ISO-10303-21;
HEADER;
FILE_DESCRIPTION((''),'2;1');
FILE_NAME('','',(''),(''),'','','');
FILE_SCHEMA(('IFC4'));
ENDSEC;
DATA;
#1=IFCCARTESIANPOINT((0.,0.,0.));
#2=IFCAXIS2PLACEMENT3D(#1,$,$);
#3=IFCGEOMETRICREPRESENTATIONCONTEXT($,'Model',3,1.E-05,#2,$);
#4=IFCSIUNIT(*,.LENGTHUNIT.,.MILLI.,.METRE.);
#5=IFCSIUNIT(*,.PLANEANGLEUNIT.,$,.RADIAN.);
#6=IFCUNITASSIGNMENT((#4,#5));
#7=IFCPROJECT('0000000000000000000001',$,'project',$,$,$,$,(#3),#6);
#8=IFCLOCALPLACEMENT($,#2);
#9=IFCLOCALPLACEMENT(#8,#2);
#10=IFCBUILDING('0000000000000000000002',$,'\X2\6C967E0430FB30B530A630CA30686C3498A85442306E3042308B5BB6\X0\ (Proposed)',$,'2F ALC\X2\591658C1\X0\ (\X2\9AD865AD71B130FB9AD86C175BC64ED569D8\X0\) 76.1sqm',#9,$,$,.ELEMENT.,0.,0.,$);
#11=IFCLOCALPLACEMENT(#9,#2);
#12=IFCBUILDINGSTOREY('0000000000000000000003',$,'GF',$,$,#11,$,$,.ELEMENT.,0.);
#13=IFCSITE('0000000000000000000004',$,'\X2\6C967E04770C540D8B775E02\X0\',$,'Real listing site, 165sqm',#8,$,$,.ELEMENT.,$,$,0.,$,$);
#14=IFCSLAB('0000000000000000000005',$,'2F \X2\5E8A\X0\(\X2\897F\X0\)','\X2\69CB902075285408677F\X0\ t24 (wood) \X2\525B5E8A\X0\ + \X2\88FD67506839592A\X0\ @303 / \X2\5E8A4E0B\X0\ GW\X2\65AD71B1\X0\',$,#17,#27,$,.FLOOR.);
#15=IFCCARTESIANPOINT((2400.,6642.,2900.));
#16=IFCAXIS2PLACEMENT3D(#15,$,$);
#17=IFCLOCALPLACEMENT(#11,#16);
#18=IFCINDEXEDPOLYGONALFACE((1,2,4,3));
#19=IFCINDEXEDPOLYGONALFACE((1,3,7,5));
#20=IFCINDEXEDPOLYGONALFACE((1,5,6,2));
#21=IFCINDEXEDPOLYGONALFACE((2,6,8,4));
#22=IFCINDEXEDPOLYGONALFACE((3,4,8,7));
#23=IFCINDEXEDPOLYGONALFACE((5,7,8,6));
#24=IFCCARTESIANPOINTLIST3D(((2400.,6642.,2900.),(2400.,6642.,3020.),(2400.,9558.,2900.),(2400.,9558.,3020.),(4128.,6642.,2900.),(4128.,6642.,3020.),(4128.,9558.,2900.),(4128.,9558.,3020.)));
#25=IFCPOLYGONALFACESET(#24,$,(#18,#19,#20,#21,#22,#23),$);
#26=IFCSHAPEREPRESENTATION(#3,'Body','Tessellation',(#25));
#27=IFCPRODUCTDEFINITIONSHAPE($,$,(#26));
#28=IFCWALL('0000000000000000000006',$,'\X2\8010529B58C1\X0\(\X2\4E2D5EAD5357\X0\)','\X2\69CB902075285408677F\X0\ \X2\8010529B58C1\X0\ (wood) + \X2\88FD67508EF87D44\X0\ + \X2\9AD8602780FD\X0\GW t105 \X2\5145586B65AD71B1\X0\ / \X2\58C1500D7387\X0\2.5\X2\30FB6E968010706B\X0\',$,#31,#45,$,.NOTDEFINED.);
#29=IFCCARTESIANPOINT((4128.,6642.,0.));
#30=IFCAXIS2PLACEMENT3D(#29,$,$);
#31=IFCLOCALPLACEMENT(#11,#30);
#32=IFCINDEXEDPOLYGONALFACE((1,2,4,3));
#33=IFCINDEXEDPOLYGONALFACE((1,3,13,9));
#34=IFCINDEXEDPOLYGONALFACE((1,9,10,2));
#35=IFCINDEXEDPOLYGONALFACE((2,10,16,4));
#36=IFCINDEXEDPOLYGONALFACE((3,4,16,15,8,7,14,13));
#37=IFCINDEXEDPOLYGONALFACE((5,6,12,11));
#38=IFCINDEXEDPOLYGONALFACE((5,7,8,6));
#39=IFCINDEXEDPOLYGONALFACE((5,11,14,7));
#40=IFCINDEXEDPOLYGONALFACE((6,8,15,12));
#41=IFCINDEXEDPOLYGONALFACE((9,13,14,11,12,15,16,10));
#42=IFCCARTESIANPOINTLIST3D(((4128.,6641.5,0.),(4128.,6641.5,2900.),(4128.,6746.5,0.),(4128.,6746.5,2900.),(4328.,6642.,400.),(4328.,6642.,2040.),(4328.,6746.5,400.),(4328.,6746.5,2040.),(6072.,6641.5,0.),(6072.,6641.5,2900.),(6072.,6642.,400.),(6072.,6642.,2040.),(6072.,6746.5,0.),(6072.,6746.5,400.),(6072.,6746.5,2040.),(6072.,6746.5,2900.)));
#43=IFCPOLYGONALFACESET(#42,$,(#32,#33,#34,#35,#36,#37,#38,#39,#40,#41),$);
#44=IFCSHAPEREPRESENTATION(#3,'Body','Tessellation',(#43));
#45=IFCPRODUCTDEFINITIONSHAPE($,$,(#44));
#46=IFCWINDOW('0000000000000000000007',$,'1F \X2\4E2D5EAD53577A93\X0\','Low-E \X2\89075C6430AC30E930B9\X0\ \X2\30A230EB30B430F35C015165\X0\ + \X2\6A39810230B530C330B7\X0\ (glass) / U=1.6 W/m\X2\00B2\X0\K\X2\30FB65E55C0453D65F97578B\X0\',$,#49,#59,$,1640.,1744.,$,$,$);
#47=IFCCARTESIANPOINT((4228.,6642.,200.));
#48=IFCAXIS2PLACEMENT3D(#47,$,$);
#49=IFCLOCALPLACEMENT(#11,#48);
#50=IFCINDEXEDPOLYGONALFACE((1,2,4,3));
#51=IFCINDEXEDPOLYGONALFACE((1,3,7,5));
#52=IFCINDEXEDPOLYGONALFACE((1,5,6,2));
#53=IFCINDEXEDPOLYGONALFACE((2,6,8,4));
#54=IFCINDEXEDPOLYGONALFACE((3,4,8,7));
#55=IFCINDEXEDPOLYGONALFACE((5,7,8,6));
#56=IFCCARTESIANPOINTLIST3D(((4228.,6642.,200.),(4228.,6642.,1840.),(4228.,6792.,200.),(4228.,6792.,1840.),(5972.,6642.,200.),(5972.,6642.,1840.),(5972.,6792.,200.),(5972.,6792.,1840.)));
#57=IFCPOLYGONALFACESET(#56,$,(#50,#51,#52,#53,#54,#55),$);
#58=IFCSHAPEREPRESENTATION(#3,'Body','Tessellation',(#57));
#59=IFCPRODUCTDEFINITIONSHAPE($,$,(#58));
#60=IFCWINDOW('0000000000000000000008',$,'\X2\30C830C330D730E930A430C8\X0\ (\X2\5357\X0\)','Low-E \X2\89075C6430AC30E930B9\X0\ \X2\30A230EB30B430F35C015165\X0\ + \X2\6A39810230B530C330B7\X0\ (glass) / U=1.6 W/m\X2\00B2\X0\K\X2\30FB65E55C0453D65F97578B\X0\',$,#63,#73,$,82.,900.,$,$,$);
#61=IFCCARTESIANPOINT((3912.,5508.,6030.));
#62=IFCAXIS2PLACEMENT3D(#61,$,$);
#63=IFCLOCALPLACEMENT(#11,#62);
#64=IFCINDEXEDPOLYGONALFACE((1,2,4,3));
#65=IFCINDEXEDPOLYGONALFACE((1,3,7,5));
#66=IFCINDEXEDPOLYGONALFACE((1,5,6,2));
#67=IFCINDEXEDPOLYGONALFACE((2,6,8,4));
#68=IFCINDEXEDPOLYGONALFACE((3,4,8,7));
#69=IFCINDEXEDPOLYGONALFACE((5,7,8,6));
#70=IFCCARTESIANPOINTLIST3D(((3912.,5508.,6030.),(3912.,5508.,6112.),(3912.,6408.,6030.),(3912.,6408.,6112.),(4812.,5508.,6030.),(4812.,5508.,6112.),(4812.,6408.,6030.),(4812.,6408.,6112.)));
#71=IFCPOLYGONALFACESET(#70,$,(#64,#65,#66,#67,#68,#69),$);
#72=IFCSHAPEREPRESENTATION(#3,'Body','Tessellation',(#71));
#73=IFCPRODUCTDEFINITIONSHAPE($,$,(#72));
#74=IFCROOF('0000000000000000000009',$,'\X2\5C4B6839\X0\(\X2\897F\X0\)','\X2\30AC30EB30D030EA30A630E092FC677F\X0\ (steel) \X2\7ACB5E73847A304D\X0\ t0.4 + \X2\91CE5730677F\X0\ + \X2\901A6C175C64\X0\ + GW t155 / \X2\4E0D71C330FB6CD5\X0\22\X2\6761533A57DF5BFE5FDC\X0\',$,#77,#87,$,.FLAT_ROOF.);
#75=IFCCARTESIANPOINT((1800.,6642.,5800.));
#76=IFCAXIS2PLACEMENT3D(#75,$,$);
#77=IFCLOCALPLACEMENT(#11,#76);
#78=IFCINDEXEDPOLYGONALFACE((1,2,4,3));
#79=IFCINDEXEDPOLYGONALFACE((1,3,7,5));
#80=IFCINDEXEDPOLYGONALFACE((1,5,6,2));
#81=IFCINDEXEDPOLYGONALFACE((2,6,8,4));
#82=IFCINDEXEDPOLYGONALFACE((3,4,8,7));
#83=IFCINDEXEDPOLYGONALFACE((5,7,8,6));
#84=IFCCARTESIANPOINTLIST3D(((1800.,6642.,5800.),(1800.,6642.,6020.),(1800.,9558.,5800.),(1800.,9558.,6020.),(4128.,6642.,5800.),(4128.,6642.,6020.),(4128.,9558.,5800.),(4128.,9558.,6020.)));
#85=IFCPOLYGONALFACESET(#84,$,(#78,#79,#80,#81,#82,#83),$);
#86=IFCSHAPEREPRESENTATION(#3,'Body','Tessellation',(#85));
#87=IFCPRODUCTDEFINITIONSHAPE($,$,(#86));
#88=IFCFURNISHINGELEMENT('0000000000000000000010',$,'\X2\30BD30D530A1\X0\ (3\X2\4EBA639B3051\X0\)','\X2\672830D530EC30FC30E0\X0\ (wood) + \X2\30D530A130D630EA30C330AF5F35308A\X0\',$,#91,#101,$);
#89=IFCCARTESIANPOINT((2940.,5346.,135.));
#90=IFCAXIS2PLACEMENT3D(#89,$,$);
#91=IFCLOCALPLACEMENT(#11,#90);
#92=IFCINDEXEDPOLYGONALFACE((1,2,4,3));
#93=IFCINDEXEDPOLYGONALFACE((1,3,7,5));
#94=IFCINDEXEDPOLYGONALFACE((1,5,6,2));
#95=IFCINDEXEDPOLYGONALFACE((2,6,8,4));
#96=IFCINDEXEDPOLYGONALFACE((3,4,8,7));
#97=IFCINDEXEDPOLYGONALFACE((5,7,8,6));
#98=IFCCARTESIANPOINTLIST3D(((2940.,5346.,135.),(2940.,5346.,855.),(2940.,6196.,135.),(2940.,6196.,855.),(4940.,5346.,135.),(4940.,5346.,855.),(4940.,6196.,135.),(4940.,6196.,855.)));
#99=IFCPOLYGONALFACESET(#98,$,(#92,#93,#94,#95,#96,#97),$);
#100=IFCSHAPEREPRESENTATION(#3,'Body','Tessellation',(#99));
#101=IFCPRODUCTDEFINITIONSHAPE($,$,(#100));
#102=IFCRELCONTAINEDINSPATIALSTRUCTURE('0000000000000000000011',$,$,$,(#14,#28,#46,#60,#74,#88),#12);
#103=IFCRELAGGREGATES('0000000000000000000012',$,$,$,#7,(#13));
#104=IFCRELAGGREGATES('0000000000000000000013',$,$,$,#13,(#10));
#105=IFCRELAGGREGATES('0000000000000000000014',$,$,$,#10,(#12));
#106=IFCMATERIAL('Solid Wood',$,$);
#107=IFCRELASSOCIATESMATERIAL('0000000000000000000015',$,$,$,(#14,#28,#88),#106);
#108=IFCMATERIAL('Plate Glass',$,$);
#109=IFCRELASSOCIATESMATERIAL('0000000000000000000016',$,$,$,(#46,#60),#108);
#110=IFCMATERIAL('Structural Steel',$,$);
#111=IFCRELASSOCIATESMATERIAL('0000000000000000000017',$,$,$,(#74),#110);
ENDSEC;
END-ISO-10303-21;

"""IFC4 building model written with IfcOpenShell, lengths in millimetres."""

from ifc_helpers import new_model, si_unit, frame, frame_2d, origin, place, context, project, spatial, rectangle, extrude, material, element, fill, save


model = new_model("IFC4")

# Units and contexts
model_context = context("Model", 3, precision=1e-05, world=origin())
ifc_project = project(units=[si_unit("LENGTHUNIT", "METRE", prefix="MILLI"), si_unit("PLANEANGLEUNIT", "RADIAN")], contexts=[model_context])

# Site, building, storey
site_placement = place(None, origin())
site = spatial("IfcSite", under=ifc_project, at=site_placement, Name="沖縄県名護市", ObjectType="Real listing site, 165sqm", CompositionType="ELEMENT", RefElevation=0.0)
building_placement = place(site_placement, origin())
building = spatial("IfcBuilding", under=site, at=building_placement, Name="沖縄・サウナと水風呂のある家 (Proposed)", ObjectType="2F ALC外壁 (高断熱・高気密仕様) 76.1sqm", CompositionType="ELEMENT", ElevationOfRefHeight=0.0, ElevationOfTerrain=0.0)
storey_placement = place(building_placement, origin())
storey = spatial("IfcBuildingStorey", under=building, at=storey_placement, Name="GF", CompositionType="ELEMENT", Elevation=0.0)

# Shared definitions
ifc_material_1 = material(Name="Solid Wood")

# Slab
slab_1_placement = place(storey_placement, frame((2400.0, 6642.0, 2900.0)))
element("IfcSlab", 1, at=slab_1_placement, inside=storey, material=ifc_material_1, Name="2F 床(西)", Description="構造用合板 t24 (wood) 剛床 + 製材根太 @303 / 床下 GW断熱", PredefinedType="FLOOR", context=model_context, shape_type="SweptSolid", body=[
    extrude(rectangle(XDim=1728.0, YDim=2916.0, at=frame_2d((864.0, 1458.0))), frame((2400.0, 6642.0, 2900.0)), (0.0, 0.0, 1.0), 120.0),
])

# Wall, opening, window
wall_placement = place(storey_placement, frame((4128.0, 6642.0, 0.0)))
wall = element("IfcWall", 2, at=wall_placement, inside=storey, material=ifc_material_1, Name="耐力壁(中庭南)", Description="構造用合板 耐力壁 (wood) + 製材軸組 + 高性能GW t105 充填断熱 / 壁倍率2.5・準耐火", PredefinedType="NOTDEFINED", context=model_context, shape_type="SweptSolid", body=[
    extrude(rectangle(XDim=1944.0, YDim=105.0, at=frame_2d((972.0, 52.0))), frame((4128.0, 6642.0, 0.0)), (0.0, 0.0, 1.0), 2900.0),
])
opening_placement = place(storey_placement, frame((4228.0, 6642.0, 200.0)))
opening = element("IfcOpeningElement", 3, at=opening_placement, cuts=wall, PredefinedType="NOTDEFINED", context=model_context, shape_type="SweptSolid", body=[
    extrude(rectangle(XDim=1744.0, YDim=150.0, at=frame_2d((872.0, 75.0))), frame((4228.0, 6642.0, 200.0)), (0.0, 0.0, 1.0), 1640.0),
])
ifc_material_2 = material(Name="Plate Glass")
window_1_placement = place(storey_placement, frame((4228.0, 6642.0, 200.0)))
window_1 = element("IfcWindow", 4, at=window_1_placement, inside=storey, material=ifc_material_2, Name="1F 中庭南窓", Description="Low-E 複層ガラス アルゴン封入 + 樹脂サッシ (glass) / U=1.6 W/m²K・日射取得型", OverallHeight=1640.0, OverallWidth=1744.0, context=model_context, shape_type="SweptSolid", body=[
    extrude(rectangle(XDim=1744.0, YDim=150.0, at=frame_2d((872.0, 75.0))), frame((4228.0, 6642.0, 200.0)), (0.0, 0.0, 1.0), 1640.0),
])
fill(opening, window_1)

# Window
window_2_placement = place(storey_placement, frame((3912.0, 5508.0, 6030.0)))
element("IfcWindow", 5, at=window_2_placement, inside=storey, material=ifc_material_2, Name="トップライト (南)", Description="Low-E 複層ガラス アルゴン封入 + 樹脂サッシ (glass) / U=1.6 W/m²K・日射取得型", OverallHeight=82.0, OverallWidth=900.0, context=model_context, shape_type="SweptSolid", body=[
    extrude(rectangle(XDim=900.0, YDim=900.0, at=frame_2d((450.0, 450.0))), frame((3912.0, 5508.0, 6030.0)), (0.0, 0.0, 1.0), 82.0),
])

# Roof
ifc_material_3 = material(Name="Structural Steel")
for number, where, name in (
    (6, (1800.0, 6642.0, 5800.0), "屋根(西)"),
):
    element("IfcRoof", number, at=place(storey_placement, frame(where)), inside=storey, material=ifc_material_3, Name=name, Description="ガルバリウム鋼板 (steel) 立平葺き t0.4 + 野地板 + 通気層 + GW t155 / 不燃・法22条区域対応", PredefinedType="FLAT_ROOF", context=model_context, shape_type="SweptSolid", body=[
        extrude(rectangle(XDim=2328.0, YDim=2916.0, at=frame_2d((1164.0, 1458.0))), frame((1800.0, 6642.0, 5800.0)), (0.0, 0.0, 1.0), 220.0),
    ])

# Furnishing element
furnishing_placement = place(storey_placement, frame((2940.0, 5346.0, 135.0)))
element("IfcFurnishingElement", 7, at=furnishing_placement, inside=storey, material=ifc_material_1, Name="ソファ (3人掛け)", Description="木フレーム (wood) + ファブリック張り", context=model_context, shape_type="SweptSolid", body=[
    extrude(rectangle(XDim=2000.0, YDim=850.0, at=frame_2d((1000.0, 425.0))), frame((2940.0, 5346.0, 135.0)), (0.0, 0.0, 1.0), 720.0),
])

save(model, "model.ifc")
